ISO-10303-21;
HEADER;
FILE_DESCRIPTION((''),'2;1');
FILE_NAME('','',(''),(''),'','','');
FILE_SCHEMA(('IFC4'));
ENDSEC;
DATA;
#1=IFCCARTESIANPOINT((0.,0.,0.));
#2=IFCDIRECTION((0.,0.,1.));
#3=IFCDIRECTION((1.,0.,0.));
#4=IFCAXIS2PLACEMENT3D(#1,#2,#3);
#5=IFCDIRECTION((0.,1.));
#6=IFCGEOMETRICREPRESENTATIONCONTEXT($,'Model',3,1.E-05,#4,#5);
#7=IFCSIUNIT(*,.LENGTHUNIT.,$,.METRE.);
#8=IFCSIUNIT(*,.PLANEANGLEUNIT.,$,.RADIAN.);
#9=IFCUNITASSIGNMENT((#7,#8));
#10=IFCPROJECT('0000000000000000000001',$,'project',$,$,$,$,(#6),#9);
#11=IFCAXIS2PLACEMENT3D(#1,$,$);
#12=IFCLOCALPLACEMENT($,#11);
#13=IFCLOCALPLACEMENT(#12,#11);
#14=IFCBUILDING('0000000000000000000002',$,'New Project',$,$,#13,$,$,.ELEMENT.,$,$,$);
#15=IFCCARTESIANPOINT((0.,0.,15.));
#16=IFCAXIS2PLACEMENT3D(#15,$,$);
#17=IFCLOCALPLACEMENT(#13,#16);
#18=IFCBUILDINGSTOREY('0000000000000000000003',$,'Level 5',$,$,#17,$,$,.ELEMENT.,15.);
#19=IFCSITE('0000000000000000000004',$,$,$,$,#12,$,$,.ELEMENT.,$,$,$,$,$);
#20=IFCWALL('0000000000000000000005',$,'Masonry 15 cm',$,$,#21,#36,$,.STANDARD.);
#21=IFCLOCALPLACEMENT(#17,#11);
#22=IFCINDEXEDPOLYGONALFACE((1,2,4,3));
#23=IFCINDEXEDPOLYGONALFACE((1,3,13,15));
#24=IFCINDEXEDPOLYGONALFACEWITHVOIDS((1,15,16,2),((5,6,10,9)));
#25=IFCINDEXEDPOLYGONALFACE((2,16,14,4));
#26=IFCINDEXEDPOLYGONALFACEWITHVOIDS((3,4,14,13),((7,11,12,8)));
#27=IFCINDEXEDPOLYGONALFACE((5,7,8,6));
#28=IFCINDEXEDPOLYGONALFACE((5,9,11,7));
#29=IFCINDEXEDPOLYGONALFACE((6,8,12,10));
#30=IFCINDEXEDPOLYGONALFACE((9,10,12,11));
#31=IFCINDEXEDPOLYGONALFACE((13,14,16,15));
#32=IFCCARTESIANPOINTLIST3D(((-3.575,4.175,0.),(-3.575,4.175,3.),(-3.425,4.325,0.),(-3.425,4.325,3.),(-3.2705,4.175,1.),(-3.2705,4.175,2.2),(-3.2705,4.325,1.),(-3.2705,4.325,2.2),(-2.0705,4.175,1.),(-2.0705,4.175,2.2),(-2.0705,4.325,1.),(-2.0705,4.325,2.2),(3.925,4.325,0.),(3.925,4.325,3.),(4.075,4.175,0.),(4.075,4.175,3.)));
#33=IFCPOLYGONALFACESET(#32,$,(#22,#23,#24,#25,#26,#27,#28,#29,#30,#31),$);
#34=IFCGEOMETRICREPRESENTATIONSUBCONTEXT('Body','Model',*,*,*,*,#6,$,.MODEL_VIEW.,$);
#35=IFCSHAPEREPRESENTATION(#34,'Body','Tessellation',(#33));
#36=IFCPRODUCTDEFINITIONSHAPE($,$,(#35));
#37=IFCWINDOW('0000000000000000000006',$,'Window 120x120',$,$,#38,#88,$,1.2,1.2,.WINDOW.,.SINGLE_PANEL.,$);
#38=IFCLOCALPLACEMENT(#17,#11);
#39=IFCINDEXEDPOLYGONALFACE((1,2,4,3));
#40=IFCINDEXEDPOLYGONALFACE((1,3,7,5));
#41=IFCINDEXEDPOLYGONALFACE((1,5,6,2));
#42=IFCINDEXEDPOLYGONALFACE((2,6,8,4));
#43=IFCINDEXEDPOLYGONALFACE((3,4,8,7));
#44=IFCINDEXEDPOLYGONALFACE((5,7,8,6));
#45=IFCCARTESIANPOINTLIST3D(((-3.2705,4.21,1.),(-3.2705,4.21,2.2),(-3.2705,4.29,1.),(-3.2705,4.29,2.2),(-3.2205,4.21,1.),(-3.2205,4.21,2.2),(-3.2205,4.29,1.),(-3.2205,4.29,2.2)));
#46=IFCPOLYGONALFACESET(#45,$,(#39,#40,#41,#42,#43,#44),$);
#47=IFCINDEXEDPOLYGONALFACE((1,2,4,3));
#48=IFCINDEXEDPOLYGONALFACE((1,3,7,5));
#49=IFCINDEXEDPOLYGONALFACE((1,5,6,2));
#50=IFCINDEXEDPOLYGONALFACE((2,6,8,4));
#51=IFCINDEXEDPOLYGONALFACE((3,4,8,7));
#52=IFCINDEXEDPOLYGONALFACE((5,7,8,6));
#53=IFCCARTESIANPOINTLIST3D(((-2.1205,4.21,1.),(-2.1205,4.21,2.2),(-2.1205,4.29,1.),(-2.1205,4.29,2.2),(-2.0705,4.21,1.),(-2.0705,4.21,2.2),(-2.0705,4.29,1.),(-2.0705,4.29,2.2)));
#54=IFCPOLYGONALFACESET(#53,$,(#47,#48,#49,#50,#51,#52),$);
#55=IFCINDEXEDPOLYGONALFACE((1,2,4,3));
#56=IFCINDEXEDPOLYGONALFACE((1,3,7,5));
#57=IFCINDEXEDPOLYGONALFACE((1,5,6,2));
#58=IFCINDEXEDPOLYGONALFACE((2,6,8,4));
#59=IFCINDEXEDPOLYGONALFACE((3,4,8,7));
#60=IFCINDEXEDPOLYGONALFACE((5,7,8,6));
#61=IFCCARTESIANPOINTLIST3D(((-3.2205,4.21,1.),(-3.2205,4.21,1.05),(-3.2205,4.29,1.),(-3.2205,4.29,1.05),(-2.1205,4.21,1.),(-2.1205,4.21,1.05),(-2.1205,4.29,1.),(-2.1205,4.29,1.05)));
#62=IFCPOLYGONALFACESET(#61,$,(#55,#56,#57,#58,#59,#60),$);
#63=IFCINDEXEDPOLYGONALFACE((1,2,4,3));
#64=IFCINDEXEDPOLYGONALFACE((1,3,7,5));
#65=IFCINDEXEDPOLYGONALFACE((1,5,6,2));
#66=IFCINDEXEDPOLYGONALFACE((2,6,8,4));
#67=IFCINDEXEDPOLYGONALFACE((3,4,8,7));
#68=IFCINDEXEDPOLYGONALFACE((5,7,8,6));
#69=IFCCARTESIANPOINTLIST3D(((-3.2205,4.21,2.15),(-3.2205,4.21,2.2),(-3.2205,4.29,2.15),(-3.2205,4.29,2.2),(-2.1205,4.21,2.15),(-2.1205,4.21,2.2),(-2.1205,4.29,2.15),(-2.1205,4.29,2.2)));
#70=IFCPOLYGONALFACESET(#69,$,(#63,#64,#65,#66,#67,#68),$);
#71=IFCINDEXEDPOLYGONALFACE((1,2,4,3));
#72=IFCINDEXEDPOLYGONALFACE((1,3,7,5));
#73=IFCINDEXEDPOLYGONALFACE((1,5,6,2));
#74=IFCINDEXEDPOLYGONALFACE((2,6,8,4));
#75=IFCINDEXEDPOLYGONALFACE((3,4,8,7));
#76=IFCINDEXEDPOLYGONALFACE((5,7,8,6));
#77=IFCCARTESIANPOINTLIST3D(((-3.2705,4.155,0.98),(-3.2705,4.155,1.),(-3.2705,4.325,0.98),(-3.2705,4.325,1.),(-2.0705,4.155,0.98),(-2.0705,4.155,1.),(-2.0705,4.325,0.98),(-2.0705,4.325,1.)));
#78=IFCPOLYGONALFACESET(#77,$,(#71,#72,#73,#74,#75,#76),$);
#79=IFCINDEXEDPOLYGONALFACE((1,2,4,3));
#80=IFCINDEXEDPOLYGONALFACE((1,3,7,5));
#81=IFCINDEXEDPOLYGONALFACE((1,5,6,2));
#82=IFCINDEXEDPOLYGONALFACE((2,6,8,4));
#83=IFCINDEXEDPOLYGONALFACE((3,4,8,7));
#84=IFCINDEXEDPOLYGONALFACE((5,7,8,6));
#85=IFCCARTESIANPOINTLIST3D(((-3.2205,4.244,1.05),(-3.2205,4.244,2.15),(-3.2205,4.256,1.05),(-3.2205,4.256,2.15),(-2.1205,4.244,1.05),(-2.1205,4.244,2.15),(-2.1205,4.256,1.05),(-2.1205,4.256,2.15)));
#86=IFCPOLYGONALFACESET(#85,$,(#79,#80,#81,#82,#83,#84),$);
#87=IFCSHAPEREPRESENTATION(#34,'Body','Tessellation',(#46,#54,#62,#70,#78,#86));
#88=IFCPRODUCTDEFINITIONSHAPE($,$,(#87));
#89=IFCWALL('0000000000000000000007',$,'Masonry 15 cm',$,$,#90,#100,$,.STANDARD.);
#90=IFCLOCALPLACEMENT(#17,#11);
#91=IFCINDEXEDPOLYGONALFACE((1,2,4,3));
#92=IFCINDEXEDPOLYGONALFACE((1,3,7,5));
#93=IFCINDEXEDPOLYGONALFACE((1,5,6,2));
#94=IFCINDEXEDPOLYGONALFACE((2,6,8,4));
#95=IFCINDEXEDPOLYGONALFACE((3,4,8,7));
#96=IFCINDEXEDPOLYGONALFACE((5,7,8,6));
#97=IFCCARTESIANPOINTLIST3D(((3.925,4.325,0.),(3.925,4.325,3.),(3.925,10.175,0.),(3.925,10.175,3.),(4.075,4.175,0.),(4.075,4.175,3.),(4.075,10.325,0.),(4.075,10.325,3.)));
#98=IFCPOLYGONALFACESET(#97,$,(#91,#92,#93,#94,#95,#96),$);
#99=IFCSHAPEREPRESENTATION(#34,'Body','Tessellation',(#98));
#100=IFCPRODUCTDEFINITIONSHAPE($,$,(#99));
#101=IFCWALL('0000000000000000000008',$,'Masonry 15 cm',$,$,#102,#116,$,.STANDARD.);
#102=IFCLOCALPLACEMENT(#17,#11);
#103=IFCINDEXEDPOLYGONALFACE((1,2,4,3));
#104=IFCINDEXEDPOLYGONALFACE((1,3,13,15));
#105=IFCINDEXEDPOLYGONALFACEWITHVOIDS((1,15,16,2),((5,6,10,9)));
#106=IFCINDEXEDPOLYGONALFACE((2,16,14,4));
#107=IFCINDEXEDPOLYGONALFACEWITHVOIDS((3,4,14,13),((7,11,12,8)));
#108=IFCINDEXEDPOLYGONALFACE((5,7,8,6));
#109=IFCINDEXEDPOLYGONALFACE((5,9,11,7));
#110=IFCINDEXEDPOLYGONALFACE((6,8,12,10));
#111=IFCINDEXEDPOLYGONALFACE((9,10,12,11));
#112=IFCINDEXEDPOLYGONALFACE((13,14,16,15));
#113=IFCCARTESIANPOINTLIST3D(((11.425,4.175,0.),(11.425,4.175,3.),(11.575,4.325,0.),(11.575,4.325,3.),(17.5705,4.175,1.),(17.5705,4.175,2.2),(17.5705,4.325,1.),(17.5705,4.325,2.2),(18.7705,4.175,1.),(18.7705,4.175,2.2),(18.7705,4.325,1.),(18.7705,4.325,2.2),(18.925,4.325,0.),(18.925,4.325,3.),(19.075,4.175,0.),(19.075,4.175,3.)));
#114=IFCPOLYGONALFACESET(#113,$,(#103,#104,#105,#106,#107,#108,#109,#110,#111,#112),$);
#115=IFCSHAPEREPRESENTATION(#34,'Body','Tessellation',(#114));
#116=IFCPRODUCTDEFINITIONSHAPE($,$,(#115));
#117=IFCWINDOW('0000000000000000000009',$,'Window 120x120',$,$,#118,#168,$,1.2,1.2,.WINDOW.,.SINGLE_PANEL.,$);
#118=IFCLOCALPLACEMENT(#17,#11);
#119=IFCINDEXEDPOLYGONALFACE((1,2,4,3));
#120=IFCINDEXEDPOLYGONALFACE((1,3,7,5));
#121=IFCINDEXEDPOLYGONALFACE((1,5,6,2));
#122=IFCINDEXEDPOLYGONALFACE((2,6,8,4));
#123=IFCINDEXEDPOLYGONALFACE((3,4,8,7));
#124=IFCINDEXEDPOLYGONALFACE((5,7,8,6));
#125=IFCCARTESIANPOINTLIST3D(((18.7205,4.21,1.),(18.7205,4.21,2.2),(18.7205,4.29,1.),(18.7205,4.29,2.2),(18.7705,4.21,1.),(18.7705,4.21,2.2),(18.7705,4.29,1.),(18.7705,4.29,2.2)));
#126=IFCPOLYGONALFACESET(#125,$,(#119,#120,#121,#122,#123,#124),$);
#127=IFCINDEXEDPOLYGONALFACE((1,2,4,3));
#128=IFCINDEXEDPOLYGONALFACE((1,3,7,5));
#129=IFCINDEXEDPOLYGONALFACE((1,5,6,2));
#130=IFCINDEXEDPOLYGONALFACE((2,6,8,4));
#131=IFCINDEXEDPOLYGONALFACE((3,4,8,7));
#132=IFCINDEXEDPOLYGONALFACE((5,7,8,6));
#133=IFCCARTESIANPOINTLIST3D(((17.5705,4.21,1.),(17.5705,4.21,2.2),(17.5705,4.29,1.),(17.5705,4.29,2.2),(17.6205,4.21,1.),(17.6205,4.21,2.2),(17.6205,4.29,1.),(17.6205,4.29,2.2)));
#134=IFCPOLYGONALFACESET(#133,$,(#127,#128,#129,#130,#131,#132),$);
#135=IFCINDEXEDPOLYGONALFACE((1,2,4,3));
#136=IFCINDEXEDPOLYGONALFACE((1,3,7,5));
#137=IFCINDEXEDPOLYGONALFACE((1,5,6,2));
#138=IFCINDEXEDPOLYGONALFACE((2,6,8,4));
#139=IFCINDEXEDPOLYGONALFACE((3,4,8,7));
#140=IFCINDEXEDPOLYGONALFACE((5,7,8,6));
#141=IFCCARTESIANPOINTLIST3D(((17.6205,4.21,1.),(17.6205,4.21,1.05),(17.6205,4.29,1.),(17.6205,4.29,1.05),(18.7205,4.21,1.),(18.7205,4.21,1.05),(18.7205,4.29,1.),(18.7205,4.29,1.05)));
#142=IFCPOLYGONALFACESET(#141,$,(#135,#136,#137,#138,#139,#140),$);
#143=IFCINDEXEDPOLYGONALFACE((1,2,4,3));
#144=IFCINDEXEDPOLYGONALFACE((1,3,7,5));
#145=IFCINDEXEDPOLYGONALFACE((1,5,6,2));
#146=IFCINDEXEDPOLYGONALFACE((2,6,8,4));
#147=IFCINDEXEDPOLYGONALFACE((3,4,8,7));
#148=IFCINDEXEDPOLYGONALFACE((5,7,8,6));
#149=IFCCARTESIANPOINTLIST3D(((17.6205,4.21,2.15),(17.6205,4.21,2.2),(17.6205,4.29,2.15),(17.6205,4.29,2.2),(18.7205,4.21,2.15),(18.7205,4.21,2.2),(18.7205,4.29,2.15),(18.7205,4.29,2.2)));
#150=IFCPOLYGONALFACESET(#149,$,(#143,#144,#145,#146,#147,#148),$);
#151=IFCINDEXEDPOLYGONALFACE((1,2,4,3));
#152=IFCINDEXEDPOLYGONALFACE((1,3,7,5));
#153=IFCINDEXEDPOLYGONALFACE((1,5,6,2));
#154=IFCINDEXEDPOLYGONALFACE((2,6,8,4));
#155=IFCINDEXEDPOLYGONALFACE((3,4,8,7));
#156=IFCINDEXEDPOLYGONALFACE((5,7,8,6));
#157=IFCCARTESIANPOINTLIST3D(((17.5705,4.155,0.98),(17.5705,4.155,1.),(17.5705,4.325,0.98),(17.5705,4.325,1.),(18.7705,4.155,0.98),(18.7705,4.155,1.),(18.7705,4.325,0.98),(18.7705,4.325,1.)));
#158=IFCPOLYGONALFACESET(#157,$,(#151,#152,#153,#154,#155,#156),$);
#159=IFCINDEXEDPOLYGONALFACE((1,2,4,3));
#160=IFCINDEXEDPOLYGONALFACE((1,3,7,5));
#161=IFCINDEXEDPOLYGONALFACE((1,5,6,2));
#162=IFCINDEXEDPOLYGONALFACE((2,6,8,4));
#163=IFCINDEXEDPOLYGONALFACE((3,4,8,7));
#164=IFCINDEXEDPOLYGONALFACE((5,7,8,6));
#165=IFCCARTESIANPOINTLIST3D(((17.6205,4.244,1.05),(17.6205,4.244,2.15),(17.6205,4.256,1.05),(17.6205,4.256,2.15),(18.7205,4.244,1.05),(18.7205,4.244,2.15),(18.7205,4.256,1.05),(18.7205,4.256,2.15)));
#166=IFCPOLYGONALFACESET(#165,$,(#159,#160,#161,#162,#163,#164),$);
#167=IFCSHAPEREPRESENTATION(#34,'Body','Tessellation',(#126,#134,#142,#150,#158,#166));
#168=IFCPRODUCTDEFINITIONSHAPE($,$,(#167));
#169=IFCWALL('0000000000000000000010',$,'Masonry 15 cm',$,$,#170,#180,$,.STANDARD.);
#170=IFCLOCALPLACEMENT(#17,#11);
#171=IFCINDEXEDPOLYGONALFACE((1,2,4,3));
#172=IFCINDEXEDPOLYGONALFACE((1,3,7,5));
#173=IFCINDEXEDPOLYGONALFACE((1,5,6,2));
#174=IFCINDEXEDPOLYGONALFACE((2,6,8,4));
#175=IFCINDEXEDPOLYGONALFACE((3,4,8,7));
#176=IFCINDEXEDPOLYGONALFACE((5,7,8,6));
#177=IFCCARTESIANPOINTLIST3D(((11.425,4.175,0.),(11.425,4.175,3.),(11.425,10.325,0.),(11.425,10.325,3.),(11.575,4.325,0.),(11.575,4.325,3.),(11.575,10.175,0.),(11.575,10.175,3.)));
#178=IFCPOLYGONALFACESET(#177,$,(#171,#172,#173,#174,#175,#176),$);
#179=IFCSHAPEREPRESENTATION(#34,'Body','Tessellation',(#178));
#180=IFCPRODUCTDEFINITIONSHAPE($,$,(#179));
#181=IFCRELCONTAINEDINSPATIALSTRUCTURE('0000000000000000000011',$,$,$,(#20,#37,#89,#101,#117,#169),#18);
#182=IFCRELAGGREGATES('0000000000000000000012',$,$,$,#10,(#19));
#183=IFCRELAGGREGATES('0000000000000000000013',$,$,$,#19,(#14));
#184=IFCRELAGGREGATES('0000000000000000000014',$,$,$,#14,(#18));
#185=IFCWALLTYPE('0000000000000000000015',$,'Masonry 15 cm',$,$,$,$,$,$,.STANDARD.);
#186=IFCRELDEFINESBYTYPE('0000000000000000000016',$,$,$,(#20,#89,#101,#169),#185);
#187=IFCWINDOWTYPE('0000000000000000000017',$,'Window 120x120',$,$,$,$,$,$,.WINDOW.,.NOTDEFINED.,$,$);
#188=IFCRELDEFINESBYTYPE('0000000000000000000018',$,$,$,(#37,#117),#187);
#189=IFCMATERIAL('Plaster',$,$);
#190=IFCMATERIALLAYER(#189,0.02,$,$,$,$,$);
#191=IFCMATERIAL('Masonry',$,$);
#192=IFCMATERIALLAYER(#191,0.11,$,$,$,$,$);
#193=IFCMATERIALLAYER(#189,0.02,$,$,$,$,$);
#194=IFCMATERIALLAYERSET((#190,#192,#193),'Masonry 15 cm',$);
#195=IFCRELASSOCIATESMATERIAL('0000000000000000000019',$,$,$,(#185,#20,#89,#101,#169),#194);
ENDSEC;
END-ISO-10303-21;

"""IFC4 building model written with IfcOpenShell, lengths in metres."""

from ifc_helpers import new_model, si_unit, direction, frame, frame_2d, origin, origin_with_axes, place, context, subcontext, project, spatial, polyline, rectangle, outline, extrude, material, layer, layer_set, layer_usage, type_object, element, fill, save


model = new_model("IFC4")

# Units and contexts
model_context = context("Model", 3, precision=1e-05, world=origin_with_axes(), true_north=direction((0.0, 1.0)))
body_context = subcontext(model_context, "Body", "Model", "MODEL_VIEW")
ifc_project = project(units=[si_unit("LENGTHUNIT", "METRE"), si_unit("PLANEANGLEUNIT", "RADIAN")], contexts=[model_context])

# Site, building, storey
site_placement = place(None, origin())
site = spatial("IfcSite", under=ifc_project, at=site_placement, CompositionType="ELEMENT")
building_placement = place(site_placement, origin())
building = spatial("IfcBuilding", under=site, at=building_placement, Name="New Project", CompositionType="ELEMENT")
storey_placement = place(building_placement, frame((0.0, 0.0, 15.0)))
storey = spatial("IfcBuildingStorey", under=building, at=storey_placement, Name="Level 5", CompositionType="ELEMENT", Elevation=15.0)

# Wall, opening, window
ifc_material_1 = material(Name="Plaster")
ifc_layer_1 = layer(ifc_material_1, 0.02)
ifc_material_2 = material(Name="Masonry")
ifc_layer_2 = layer(ifc_material_2, 0.11)
ifc_layer_3 = layer(ifc_material_1, 0.02)
ifc_layer_set_1 = layer_set([ifc_layer_1, ifc_layer_2, ifc_layer_3], Name="Masonry 15 cm")
ifc_layer_usage_1 = layer_usage(ifc_layer_set_1, "AXIS2", "NEGATIVE", 0.075)
wall_type_1 = type_object("IfcWallType", Name="Masonry 15 cm", PredefinedType="STANDARD", material=ifc_layer_set_1)
wall_1_placement = place(storey_placement, frame((4.0, 4.25, 0.0), z_axis=(0.0, 0.0, 1.0), x_axis=(-1.0, 0.0, 0.0)))
wall_1 = element("IfcWall", 1, at=wall_1_placement, inside=storey, type_object=wall_type_1, material=ifc_layer_usage_1, Name="Masonry 15 cm", PredefinedType="STANDARD", context=body_context, shape_type="SweptSolid", body=[
    extrude(outline(polyline([(0.075, -0.075), (7.425, -0.075), (7.575, 0.075), (-0.075, 0.075), (0.075, -0.075)])), origin(), (0.0, 0.0, 1.0), 3.0),
])
opening_1_placement = place(wall_1_placement, frame((6.0705, 0.0, 1.0)))
opening_1 = element("IfcOpeningElement", 2, at=opening_1_placement, cuts=wall_1, PredefinedType="OPENING", context=body_context, shape_type="SweptSolid", body=[
    extrude(rectangle(XDim=1.2, YDim=0.25, at=frame_2d((0.6, 0.0))), origin(), (0.0, 0.0, 1.0), 1.2),
])
window_type = type_object("IfcWindowType", Name="Window 120x120", PartitioningType="NOTDEFINED", PredefinedType="WINDOW")
window_1_placement = place(opening_1_placement, origin())
window_1 = element("IfcWindow", 3, at=window_1_placement, inside=storey, type_object=window_type, Name="Window 120x120", OverallHeight=1.2, OverallWidth=1.2, PartitioningType="SINGLE_PANEL", PredefinedType="WINDOW", context=body_context, shape_type="SweptSolid", body=[
    extrude(outline(polyline([(1.2, 0.04), (1.15, 0.04), (1.15, -0.04), (1.2, -0.04), (1.2, 0.04)])), origin(), (0.0, 0.0, 1.0), 1.2),
    extrude(outline(polyline([(0.05, 0.04), (0.0, 0.04), (0.0, -0.04), (0.05, -0.04), (0.05, 0.04)])), origin(), (0.0, 0.0, 1.0), 1.2),
    extrude(outline(polyline([(1.15, 0.04), (0.05, 0.04), (0.05, -0.04), (1.15, -0.04), (1.15, 0.04)])), origin(), (0.0, 0.0, 1.0), 0.05),
    extrude(outline(polyline([(1.15, 0.04), (0.05, 0.04), (0.05, -0.04), (1.15, -0.04), (1.15, 0.04)])), frame((0.0, 0.0, 1.15)), (0.0, 0.0, 1.0), 0.05),
    extrude(outline(polyline([(1.2, 0.095), (0.0, 0.095), (0.0, -0.075), (1.2, -0.075), (1.2, 0.095)])), frame((0.0, 0.0, -0.02)), (0.0, 0.0, 1.0), 0.02),
    extrude(outline(polyline([(1.15, 0.006), (0.05, 0.006), (0.05, -0.006), (1.15, -0.006), (1.15, 0.006)])), frame((0.0, 0.0, 0.05)), (0.0, 0.0, 1.0), 1.1),
])
fill(opening_1, window_1)

# Wall
wall_2_placement = place(storey_placement, frame((4.0, 10.25, 0.0), z_axis=(0.0, 0.0, 1.0), x_axis=(0.0, -1.0, 0.0)))
element("IfcWall", 4, at=wall_2_placement, inside=storey, type_object=wall_type_1, material=ifc_layer_usage_1, Name="Masonry 15 cm", PredefinedType="STANDARD", context=body_context, shape_type="SweptSolid", body=[
    extrude(outline(polyline([(0.075, -0.075), (5.925, -0.075), (6.075, 0.075), (-0.075, 0.075), (0.075, -0.075)])), origin(), (0.0, 0.0, 1.0), 3.0),
])

# Wall, opening, window
wall_3_placement = place(storey_placement, frame((19.0, 4.25, 0.0), z_axis=(0.0, 0.0, 1.0), x_axis=(-1.0, 0.0, 0.0)))
wall_3 = element("IfcWall", 5, at=wall_3_placement, inside=storey, type_object=wall_type_1, material=ifc_layer_usage_1, Name="Masonry 15 cm", PredefinedType="STANDARD", context=body_context, shape_type="SweptSolid", body=[
    extrude(outline(polyline([(0.075, -0.075), (7.425, -0.075), (7.575, 0.075), (-0.075, 0.075), (0.075, -0.075)])), origin(), (0.0, 0.0, 1.0), 3.0),
])
opening_2_placement = place(wall_3_placement, frame((0.2295, 0.0, 1.0)))
opening_2 = element("IfcOpeningElement", 6, at=opening_2_placement, cuts=wall_3, PredefinedType="OPENING", context=body_context, shape_type="SweptSolid", body=[
    extrude(rectangle(XDim=1.2, YDim=0.25, at=frame_2d((0.6, 0.0))), origin(), (0.0, 0.0, 1.0), 1.2),
])
window_2_placement = place(opening_2_placement, origin())
window_2 = element("IfcWindow", 7, at=window_2_placement, inside=storey, type_object=window_type, Name="Window 120x120", OverallHeight=1.2, OverallWidth=1.2, PartitioningType="SINGLE_PANEL", PredefinedType="WINDOW", context=body_context, shape_type="SweptSolid", body=[
    extrude(outline(polyline([(0.0, -0.04), (0.05, -0.04), (0.05, 0.04), (0.0, 0.04), (0.0, -0.04)])), origin(), (0.0, 0.0, 1.0), 1.2),
    extrude(outline(polyline([(1.15, -0.04), (1.2, -0.04), (1.2, 0.04), (1.15, 0.04), (1.15, -0.04)])), origin(), (0.0, 0.0, 1.0), 1.2),
    extrude(outline(polyline([(0.05, -0.04), (1.15, -0.04), (1.15, 0.04), (0.05, 0.04), (0.05, -0.04)])), origin(), (0.0, 0.0, 1.0), 0.05),
    extrude(outline(polyline([(0.05, -0.04), (1.15, -0.04), (1.15, 0.04), (0.05, 0.04), (0.05, -0.04)])), frame((0.0, 0.0, 1.15)), (0.0, 0.0, 1.0), 0.05),
    extrude(outline(polyline([(0.0, -0.075), (1.2, -0.075), (1.2, 0.095), (0.0, 0.095), (0.0, -0.075)])), frame((0.0, 0.0, -0.02)), (0.0, 0.0, 1.0), 0.02),
    extrude(outline(polyline([(0.05, -0.006), (1.15, -0.006), (1.15, 0.006), (0.05, 0.006), (0.05, -0.006)])), frame((0.0, 0.0, 0.05)), (0.0, 0.0, 1.0), 1.1),
])
fill(opening_2, window_2)

# Wall
wall_4_placement = place(storey_placement, frame((11.5, 4.25, 0.0), z_axis=(0.0, 0.0, 1.0), x_axis=(0.0, 1.0, 0.0)))
element("IfcWall", 8, at=wall_4_placement, inside=storey, type_object=wall_type_1, material=ifc_layer_usage_1, Name="Masonry 15 cm", PredefinedType="STANDARD", context=body_context, shape_type="SweptSolid", body=[
    extrude(outline(polyline([(0.075, -0.075), (5.925, -0.075), (6.075, 0.075), (-0.075, 0.075), (0.075, -0.075)])), origin(), (0.0, 0.0, 1.0), 3.0),
])

save(model, "model.ifc")
